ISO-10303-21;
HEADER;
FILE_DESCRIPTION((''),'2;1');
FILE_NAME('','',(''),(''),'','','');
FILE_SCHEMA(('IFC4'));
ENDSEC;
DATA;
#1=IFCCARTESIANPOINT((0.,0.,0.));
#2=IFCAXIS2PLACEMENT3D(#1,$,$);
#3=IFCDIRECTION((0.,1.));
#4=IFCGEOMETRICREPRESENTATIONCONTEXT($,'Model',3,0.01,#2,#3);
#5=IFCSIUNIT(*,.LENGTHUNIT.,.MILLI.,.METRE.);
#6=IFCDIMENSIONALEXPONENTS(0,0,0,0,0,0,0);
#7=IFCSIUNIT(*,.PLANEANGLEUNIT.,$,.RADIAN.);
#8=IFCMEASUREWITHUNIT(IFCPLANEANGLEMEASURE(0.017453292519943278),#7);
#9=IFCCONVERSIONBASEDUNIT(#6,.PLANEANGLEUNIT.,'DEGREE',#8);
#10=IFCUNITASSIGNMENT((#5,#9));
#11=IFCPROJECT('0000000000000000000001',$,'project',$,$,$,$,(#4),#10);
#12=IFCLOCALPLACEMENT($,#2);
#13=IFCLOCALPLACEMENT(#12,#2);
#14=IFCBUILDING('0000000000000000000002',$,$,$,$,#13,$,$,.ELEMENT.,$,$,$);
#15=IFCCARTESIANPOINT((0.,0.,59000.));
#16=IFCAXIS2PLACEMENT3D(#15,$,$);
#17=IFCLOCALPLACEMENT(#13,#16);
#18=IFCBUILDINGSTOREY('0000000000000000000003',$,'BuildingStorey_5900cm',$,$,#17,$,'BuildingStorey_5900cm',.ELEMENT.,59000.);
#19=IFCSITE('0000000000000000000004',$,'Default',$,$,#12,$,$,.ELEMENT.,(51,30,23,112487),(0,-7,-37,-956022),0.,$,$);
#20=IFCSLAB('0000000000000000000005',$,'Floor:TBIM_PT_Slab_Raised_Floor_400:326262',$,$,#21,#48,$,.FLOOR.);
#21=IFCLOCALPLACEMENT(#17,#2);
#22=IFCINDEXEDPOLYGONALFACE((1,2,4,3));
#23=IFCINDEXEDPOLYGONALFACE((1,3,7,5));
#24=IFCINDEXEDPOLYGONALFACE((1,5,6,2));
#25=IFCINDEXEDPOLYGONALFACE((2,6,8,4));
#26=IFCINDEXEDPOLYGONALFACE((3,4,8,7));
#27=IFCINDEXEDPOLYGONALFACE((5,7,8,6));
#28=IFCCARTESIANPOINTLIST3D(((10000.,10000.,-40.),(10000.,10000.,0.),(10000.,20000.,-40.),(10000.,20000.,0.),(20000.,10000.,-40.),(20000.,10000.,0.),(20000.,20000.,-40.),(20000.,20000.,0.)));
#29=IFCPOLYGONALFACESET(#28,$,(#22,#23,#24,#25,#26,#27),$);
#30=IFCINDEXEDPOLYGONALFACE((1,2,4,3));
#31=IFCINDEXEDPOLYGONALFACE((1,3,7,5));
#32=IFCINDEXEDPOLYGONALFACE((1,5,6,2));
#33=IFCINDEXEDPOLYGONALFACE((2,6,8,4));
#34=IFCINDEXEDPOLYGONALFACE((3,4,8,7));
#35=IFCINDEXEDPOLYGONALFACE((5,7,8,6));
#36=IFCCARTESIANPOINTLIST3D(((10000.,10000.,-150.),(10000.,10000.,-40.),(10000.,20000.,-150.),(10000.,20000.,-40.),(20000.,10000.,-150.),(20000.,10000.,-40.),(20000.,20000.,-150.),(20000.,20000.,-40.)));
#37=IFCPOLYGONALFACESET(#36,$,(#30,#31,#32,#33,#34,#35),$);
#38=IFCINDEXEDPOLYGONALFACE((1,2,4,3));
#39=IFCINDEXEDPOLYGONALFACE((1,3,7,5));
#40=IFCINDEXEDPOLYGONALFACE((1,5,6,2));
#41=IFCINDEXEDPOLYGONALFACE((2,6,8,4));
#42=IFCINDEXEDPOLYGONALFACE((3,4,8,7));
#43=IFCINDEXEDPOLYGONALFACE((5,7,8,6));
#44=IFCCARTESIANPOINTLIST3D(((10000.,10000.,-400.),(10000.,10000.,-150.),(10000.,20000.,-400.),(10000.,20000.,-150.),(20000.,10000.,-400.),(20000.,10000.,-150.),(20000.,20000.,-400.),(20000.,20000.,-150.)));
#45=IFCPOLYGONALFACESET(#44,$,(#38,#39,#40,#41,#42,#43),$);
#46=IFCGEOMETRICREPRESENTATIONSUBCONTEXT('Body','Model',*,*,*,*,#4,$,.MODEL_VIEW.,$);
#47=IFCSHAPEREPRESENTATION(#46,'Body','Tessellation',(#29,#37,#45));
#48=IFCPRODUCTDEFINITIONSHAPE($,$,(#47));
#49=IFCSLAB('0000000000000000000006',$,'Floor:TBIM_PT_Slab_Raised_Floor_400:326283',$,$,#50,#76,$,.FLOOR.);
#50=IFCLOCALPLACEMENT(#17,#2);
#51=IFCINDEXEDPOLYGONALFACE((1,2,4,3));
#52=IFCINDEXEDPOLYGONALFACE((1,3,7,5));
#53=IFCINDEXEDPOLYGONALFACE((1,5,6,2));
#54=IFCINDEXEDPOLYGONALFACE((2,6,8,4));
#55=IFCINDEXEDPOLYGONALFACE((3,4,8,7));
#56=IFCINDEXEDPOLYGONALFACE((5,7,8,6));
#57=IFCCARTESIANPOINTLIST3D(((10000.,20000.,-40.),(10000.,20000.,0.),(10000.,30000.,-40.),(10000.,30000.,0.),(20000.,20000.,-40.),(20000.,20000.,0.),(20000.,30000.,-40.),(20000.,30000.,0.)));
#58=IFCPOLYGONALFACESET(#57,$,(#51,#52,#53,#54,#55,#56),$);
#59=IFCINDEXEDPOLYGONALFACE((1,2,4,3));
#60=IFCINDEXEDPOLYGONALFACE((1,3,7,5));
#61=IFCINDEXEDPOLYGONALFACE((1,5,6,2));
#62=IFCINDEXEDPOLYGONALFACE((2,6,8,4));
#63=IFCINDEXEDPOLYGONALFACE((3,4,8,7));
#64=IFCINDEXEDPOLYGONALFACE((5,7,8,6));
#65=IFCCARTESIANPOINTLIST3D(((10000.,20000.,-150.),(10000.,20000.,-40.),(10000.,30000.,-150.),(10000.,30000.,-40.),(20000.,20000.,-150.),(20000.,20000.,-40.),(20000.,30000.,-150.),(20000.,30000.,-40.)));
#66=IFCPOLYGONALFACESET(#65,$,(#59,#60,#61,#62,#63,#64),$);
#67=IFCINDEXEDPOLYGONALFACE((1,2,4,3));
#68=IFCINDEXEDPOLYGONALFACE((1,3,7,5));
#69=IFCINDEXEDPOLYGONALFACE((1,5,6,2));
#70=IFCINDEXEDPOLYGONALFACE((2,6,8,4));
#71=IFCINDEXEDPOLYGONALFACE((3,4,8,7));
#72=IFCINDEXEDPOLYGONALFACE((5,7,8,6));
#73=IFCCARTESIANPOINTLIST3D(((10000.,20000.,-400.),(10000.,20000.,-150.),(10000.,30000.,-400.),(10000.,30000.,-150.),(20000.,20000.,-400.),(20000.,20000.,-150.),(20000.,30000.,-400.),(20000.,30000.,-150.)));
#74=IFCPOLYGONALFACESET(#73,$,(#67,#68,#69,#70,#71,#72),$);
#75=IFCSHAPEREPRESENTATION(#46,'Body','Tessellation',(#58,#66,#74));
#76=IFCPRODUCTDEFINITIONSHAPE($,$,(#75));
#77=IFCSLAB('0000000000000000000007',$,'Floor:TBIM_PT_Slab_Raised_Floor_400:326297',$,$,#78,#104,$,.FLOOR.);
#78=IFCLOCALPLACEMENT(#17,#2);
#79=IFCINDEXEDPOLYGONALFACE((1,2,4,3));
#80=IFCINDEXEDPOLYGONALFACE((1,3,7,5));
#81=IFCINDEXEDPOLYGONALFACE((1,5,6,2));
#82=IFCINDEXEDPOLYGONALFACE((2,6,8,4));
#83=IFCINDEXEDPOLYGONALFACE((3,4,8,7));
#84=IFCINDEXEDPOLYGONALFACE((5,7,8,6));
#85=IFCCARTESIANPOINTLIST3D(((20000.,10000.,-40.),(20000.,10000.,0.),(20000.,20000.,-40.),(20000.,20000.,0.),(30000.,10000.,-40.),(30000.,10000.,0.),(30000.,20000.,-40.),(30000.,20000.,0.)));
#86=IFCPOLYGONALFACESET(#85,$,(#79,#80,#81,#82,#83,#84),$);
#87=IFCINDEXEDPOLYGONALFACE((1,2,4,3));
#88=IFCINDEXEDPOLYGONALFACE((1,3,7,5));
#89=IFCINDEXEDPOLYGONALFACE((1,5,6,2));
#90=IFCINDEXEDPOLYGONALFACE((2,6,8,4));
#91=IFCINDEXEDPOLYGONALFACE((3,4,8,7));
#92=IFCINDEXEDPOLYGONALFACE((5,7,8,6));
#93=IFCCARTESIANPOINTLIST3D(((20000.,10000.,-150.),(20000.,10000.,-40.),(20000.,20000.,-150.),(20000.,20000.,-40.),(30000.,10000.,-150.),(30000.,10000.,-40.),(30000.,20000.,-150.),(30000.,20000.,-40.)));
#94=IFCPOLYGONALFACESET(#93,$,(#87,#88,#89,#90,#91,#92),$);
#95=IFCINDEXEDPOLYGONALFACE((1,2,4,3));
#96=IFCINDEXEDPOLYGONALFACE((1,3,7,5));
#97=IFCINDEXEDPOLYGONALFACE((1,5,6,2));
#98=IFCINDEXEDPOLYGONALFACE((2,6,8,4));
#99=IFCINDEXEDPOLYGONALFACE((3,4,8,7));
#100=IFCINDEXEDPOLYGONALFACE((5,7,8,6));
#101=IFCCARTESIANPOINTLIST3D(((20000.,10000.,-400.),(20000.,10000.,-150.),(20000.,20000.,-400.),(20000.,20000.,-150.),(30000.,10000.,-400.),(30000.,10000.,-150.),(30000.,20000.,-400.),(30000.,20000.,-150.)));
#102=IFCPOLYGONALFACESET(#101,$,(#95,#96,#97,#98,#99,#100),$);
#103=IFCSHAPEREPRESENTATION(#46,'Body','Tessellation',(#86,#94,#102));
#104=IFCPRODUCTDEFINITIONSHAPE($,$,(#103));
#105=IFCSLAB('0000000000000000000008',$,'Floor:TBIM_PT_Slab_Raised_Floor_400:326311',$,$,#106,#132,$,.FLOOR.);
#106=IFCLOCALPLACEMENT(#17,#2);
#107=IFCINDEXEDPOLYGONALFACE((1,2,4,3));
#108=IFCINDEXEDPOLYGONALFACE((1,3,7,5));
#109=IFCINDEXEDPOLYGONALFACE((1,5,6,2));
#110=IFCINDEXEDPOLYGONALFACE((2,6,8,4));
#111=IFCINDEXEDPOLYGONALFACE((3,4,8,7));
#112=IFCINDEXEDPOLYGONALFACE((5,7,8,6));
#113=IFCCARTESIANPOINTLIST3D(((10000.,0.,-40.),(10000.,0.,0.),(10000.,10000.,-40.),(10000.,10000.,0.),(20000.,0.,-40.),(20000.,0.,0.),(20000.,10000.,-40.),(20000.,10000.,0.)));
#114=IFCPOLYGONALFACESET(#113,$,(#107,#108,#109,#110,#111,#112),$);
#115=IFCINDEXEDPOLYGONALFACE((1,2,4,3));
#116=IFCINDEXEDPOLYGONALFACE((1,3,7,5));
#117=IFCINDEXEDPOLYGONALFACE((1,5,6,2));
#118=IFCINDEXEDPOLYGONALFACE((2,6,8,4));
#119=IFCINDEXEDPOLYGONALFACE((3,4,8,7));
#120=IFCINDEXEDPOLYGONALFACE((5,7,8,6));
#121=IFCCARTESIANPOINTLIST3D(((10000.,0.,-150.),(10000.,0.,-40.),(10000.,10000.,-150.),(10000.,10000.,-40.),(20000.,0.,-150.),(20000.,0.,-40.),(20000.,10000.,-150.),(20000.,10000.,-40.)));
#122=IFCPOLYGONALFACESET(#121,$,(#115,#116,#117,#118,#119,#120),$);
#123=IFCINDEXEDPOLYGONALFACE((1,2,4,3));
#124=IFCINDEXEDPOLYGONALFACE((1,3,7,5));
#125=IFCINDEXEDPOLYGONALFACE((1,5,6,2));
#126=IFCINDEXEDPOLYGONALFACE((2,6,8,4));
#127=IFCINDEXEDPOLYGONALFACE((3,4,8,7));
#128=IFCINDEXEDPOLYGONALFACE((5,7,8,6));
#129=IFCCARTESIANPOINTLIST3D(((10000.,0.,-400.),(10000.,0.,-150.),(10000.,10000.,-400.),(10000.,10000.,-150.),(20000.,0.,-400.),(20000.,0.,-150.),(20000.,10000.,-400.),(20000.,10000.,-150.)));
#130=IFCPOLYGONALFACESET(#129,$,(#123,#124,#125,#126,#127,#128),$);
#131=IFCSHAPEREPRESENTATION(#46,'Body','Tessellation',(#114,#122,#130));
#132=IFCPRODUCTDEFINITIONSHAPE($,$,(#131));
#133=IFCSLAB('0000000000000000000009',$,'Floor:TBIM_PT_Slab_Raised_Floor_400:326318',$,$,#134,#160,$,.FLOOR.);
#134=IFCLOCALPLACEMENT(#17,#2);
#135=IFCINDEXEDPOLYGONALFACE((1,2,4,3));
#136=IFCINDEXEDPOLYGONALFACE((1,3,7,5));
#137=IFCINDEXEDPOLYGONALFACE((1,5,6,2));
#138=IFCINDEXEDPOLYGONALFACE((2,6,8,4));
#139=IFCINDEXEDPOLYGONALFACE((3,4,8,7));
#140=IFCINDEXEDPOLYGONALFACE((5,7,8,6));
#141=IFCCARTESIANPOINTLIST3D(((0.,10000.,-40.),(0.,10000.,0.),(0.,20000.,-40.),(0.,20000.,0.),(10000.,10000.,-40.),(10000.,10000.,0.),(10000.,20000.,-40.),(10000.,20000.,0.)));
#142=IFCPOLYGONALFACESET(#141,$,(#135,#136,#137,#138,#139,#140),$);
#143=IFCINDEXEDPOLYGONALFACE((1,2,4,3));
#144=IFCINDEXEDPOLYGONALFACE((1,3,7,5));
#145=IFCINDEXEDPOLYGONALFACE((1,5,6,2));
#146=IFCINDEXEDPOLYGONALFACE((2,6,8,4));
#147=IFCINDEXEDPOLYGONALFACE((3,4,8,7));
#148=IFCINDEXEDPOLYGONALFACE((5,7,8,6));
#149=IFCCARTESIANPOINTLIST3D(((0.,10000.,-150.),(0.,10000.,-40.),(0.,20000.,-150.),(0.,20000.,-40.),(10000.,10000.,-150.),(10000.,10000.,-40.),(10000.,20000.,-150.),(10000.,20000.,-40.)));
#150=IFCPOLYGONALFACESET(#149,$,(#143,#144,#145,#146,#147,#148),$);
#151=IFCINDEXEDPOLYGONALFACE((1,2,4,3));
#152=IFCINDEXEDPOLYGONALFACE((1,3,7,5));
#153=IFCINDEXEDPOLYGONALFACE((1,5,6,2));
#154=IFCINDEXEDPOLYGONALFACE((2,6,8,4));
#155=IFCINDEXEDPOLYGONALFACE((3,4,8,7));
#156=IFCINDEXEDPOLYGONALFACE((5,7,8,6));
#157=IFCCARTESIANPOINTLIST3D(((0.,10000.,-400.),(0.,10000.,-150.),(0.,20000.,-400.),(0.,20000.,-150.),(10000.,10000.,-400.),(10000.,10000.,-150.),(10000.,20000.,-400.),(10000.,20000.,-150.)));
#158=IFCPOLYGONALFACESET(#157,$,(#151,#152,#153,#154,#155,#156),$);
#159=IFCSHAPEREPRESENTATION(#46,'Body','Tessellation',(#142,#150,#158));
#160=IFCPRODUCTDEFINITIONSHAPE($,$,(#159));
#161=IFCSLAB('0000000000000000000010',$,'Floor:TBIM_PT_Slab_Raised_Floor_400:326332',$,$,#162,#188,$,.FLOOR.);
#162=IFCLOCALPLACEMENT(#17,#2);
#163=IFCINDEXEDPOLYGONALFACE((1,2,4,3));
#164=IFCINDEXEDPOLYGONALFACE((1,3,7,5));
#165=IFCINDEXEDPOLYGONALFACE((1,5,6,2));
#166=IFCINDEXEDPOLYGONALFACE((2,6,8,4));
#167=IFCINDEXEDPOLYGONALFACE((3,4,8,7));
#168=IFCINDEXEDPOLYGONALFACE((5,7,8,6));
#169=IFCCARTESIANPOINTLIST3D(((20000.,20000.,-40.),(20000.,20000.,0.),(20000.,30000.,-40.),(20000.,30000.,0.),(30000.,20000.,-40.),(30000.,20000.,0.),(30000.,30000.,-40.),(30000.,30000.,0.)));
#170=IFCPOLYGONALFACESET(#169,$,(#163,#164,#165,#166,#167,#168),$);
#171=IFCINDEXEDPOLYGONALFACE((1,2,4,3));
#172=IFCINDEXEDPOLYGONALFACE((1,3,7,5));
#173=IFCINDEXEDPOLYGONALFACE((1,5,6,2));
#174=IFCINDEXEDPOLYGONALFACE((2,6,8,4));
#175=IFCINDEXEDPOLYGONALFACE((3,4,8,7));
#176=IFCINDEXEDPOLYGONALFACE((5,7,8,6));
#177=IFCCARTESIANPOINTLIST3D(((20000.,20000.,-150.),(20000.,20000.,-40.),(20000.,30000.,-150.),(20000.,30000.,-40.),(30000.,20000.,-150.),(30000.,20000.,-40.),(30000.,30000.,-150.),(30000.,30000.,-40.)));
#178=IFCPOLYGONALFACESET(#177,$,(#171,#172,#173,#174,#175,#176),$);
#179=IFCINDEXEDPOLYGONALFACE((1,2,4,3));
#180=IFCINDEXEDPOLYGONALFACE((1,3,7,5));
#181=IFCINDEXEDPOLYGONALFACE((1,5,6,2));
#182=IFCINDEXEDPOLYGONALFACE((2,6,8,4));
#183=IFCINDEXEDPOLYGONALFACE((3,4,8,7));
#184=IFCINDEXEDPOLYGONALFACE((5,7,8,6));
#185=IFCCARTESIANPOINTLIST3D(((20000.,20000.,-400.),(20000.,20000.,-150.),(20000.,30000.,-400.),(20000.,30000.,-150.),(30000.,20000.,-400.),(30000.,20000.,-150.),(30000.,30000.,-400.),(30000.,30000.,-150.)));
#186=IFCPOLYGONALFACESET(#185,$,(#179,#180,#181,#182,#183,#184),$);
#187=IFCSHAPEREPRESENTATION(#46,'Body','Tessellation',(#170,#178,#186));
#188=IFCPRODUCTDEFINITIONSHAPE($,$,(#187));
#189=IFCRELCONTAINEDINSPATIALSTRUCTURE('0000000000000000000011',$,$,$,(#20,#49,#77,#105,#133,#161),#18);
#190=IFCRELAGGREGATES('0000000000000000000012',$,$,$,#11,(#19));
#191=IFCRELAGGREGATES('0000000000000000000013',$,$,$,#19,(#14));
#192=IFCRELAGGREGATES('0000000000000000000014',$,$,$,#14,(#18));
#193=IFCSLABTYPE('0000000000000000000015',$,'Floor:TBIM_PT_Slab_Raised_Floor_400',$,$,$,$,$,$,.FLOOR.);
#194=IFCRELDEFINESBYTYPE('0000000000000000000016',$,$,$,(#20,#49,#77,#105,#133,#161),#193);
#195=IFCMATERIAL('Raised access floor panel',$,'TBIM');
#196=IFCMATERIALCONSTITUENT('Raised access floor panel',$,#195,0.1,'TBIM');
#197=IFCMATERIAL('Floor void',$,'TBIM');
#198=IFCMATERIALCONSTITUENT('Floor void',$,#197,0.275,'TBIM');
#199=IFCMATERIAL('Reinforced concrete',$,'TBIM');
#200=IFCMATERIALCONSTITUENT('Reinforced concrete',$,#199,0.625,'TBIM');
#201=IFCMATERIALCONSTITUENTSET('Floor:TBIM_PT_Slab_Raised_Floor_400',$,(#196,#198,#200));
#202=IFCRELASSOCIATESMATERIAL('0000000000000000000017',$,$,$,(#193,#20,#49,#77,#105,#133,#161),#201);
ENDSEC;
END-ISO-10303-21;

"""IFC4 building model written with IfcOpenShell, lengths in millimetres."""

from ifc_helpers import new_model, entity, si_unit, converted_unit, direction, frame, origin, place, context, subcontext, project, spatial, indexed_curve, outline, extrude, material, constituent, constituent_set, type_object, element, save


model = new_model("IFC4")

# Units and contexts
model_context = context("Model", 3, precision=0.01, world=origin(), true_north=direction((0.0, 1.0)))
body_context = subcontext(model_context, "Body", "Model", "MODEL_VIEW")
ifc_project = project(units=[si_unit("LENGTHUNIT", "METRE", prefix="MILLI"), converted_unit("PLANEANGLEUNIT", "DEGREE", entity("IfcPlaneAngleMeasure", 0.017453292519943278), si_unit("PLANEANGLEUNIT", "RADIAN"), dimensions=[0, 0, 0, 0, 0, 0, 0])], contexts=[model_context])

# Site, building, storey
site_placement = place(None, origin())
site = spatial("IfcSite", under=ifc_project, at=site_placement, Name="Default", CompositionType="ELEMENT", RefLatitude=(51, 30, 23, 112487), RefLongitude=(0, -7, -37, -956022), RefElevation=0.0)
building_placement = place(site_placement, origin())
building = spatial("IfcBuilding", under=site, at=building_placement, CompositionType="ELEMENT")
storey_placement = place(building_placement, frame((0.0, 0.0, 59000.0)))
storey = spatial("IfcBuildingStorey", under=building, at=storey_placement, Name="BuildingStorey_5900cm", LongName="BuildingStorey_5900cm", CompositionType="ELEMENT", Elevation=59000.0)

# Slabs
ifc_material_1 = material(Name="Raised access floor panel", Category="TBIM")
ifc_constituent_1 = constituent(ifc_material_1, Name="Raised access floor panel", Category="TBIM", fraction=0.1)
ifc_material_2 = material(Name="Floor void", Category="TBIM")
ifc_constituent_2 = constituent(ifc_material_2, Name="Floor void", Category="TBIM", fraction=0.275)
ifc_material_3 = material(Name="Reinforced concrete", Category="TBIM")
ifc_constituent_3 = constituent(ifc_material_3, Name="Reinforced concrete", Category="TBIM", fraction=0.625)
ifc_constituent_set_1 = constituent_set(constituents=[ifc_constituent_1, ifc_constituent_2, ifc_constituent_3], Name="Floor:TBIM_PT_Slab_Raised_Floor_400")
slab_type = type_object("IfcSlabType", Name="Floor:TBIM_PT_Slab_Raised_Floor_400", PredefinedType="FLOOR", material=ifc_constituent_set_1)
slab_1_placement = place(storey_placement, origin())
element("IfcSlab", 1, at=slab_1_placement, inside=storey, type_object=slab_type, material=ifc_constituent_set_1, Name="Floor:TBIM_PT_Slab_Raised_Floor_400:326262", PredefinedType="FLOOR", context=body_context, shape_type="SweptSolid", body=[
    extrude(outline(indexed_curve([(-5000.0, -5000.0), (5000.0, -5000.0), (5000.0, 5000.0), (-5000.0, 5000.0), (-5000.0, -5000.0)], self_intersect=False)), frame((15000.0, 15000.0, -40.0), z_axis=(0.0, 0.0, 1.0), x_axis=(-1.0, 0.0, 0.0)), (0.0, 0.0, 1.0), 40.0),
    extrude(outline(indexed_curve([(-5000.0, -5000.0), (5000.0, -5000.0), (5000.0, 5000.0), (-5000.0, 5000.0), (-5000.0, -5000.0)], self_intersect=False)), frame((15000.0, 15000.0, -150.0), z_axis=(0.0, 0.0, 1.0), x_axis=(-1.0, 0.0, 0.0)), (0.0, 0.0, 1.0), 110.0),
    extrude(outline(indexed_curve([(-5000.0, -5000.0), (5000.0, -5000.0), (5000.0, 5000.0), (-5000.0, 5000.0), (-5000.0, -5000.0)], self_intersect=False)), frame((15000.0, 15000.0, -400.0), z_axis=(0.0, 0.0, 1.0), x_axis=(-1.0, 0.0, 0.0)), (0.0, 0.0, 1.0), 250.0),
])
slab_2_placement = place(storey_placement, origin())
element("IfcSlab", 2, at=slab_2_placement, inside=storey, type_object=slab_type, material=ifc_constituent_set_1, Name="Floor:TBIM_PT_Slab_Raised_Floor_400:326283", PredefinedType="FLOOR", context=body_context, shape_type="SweptSolid", body=[
    extrude(outline(indexed_curve([(-5000.0, -5000.0), (5000.0, -5000.0), (5000.0, 5000.0), (-5000.0, 5000.0), (-5000.0, -5000.0)], self_intersect=False)), frame((15000.0, 25000.0, -40.0), z_axis=(0.0, 0.0, 1.0), x_axis=(-1.0, 0.0, 0.0)), (0.0, 0.0, 1.0), 40.0),
    extrude(outline(indexed_curve([(-5000.0, -5000.0), (5000.0, -5000.0), (5000.0, 5000.0), (-5000.0, 5000.0), (-5000.0, -5000.0)], self_intersect=False)), frame((15000.0, 25000.0, -150.0), z_axis=(0.0, 0.0, 1.0), x_axis=(-1.0, 0.0, 0.0)), (0.0, 0.0, 1.0), 110.0),
    extrude(outline(indexed_curve([(-5000.0, -5000.0), (5000.0, -5000.0), (5000.0, 5000.0), (-5000.0, 5000.0), (-5000.0, -5000.0)], self_intersect=False)), frame((15000.0, 25000.0, -400.0), z_axis=(0.0, 0.0, 1.0), x_axis=(-1.0, 0.0, 0.0)), (0.0, 0.0, 1.0), 250.0),
])
slab_3_placement = place(storey_placement, origin())
element("IfcSlab", 3, at=slab_3_placement, inside=storey, type_object=slab_type, material=ifc_constituent_set_1, Name="Floor:TBIM_PT_Slab_Raised_Floor_400:326297", PredefinedType="FLOOR", context=body_context, shape_type="SweptSolid", body=[
    extrude(outline(indexed_curve([(-5000.0, -5000.0), (5000.0, -5000.0), (5000.0, 5000.0), (-5000.0, 5000.0), (-5000.0, -5000.0)], self_intersect=False)), frame((25000.0, 15000.0, -40.0), z_axis=(0.0, 0.0, 1.0), x_axis=(-1.0, 0.0, 0.0)), (0.0, 0.0, 1.0), 40.0),
    extrude(outline(indexed_curve([(-5000.0, -5000.0), (5000.0, -5000.0), (5000.0, 5000.0), (-5000.0, 5000.0), (-5000.0, -5000.0)], self_intersect=False)), frame((25000.0, 15000.0, -150.0), z_axis=(0.0, 0.0, 1.0), x_axis=(-1.0, 0.0, 0.0)), (0.0, 0.0, 1.0), 110.0),
    extrude(outline(indexed_curve([(-5000.0, -5000.0), (5000.0, -5000.0), (5000.0, 5000.0), (-5000.0, 5000.0), (-5000.0, -5000.0)], self_intersect=False)), frame((25000.0, 15000.0, -400.0), z_axis=(0.0, 0.0, 1.0), x_axis=(-1.0, 0.0, 0.0)), (0.0, 0.0, 1.0), 250.0),
])
slab_4_placement = place(storey_placement, origin())
element("IfcSlab", 4, at=slab_4_placement, inside=storey, type_object=slab_type, material=ifc_constituent_set_1, Name="Floor:TBIM_PT_Slab_Raised_Floor_400:326311", PredefinedType="FLOOR", context=body_context, shape_type="SweptSolid", body=[
    extrude(outline(indexed_curve([(-5000.0, -5000.0), (5000.0, -5000.0), (5000.0, 5000.0), (-5000.0, 5000.0), (-5000.0, -5000.0)], self_intersect=False)), frame((15000.0, 5000.0, -40.0), z_axis=(0.0, 0.0, 1.0), x_axis=(0.0, 1.0, 0.0)), (0.0, 0.0, 1.0), 40.0),
    extrude(outline(indexed_curve([(-5000.0, -5000.0), (5000.0, -5000.0), (5000.0, 5000.0), (-5000.0, 5000.0), (-5000.0, -5000.0)], self_intersect=False)), frame((15000.0, 5000.0, -150.0), z_axis=(0.0, 0.0, 1.0), x_axis=(0.0, 1.0, 0.0)), (0.0, 0.0, 1.0), 110.0),
    extrude(outline(indexed_curve([(-5000.0, -5000.0), (5000.0, -5000.0), (5000.0, 5000.0), (-5000.0, 5000.0), (-5000.0, -5000.0)], self_intersect=False)), frame((15000.0, 5000.0, -400.0), z_axis=(0.0, 0.0, 1.0), x_axis=(0.0, 1.0, 0.0)), (0.0, 0.0, 1.0), 250.0),
])
slab_5_placement = place(storey_placement, origin())
element("IfcSlab", 5, at=slab_5_placement, inside=storey, type_object=slab_type, material=ifc_constituent_set_1, Name="Floor:TBIM_PT_Slab_Raised_Floor_400:326318", PredefinedType="FLOOR", context=body_context, shape_type="SweptSolid", body=[
    extrude(outline(indexed_curve([(-5000.0, -5000.0), (5000.0, -5000.0), (5000.0, 5000.0), (-5000.0, 5000.0), (-5000.0, -5000.0)], self_intersect=False)), frame((5000.0, 15000.0, -40.0), z_axis=(0.0, 0.0, 1.0), x_axis=(0.0, 1.0, 0.0)), (0.0, 0.0, 1.0), 40.0),
    extrude(outline(indexed_curve([(-5000.0, -5000.0), (5000.0, -5000.0), (5000.0, 5000.0), (-5000.0, 5000.0), (-5000.0, -5000.0)], self_intersect=False)), frame((5000.0, 15000.0, -150.0), z_axis=(0.0, 0.0, 1.0), x_axis=(0.0, 1.0, 0.0)), (0.0, 0.0, 1.0), 110.0),
    extrude(outline(indexed_curve([(-5000.0, -5000.0), (5000.0, -5000.0), (5000.0, 5000.0), (-5000.0, 5000.0), (-5000.0, -5000.0)], self_intersect=False)), frame((5000.0, 15000.0, -400.0), z_axis=(0.0, 0.0, 1.0), x_axis=(0.0, 1.0, 0.0)), (0.0, 0.0, 1.0), 250.0),
])
slab_6_placement = place(storey_placement, origin())
element("IfcSlab", 6, at=slab_6_placement, inside=storey, type_object=slab_type, material=ifc_constituent_set_1, Name="Floor:TBIM_PT_Slab_Raised_Floor_400:326332", PredefinedType="FLOOR", context=body_context, shape_type="SweptSolid", body=[
    extrude(outline(indexed_curve([(-5000.0, -5000.0), (5000.0, -5000.0), (5000.0, 5000.0), (-5000.0, 5000.0), (-5000.0, -5000.0)], self_intersect=False)), frame((25000.0, 25000.0, -40.0), z_axis=(0.0, 0.0, 1.0), x_axis=(-1.0, 0.0, 0.0)), (0.0, 0.0, 1.0), 40.0),
    extrude(outline(indexed_curve([(-5000.0, -5000.0), (5000.0, -5000.0), (5000.0, 5000.0), (-5000.0, 5000.0), (-5000.0, -5000.0)], self_intersect=False)), frame((25000.0, 25000.0, -150.0), z_axis=(0.0, 0.0, 1.0), x_axis=(-1.0, 0.0, 0.0)), (0.0, 0.0, 1.0), 110.0),
    extrude(outline(indexed_curve([(-5000.0, -5000.0), (5000.0, -5000.0), (5000.0, 5000.0), (-5000.0, 5000.0), (-5000.0, -5000.0)], self_intersect=False)), frame((25000.0, 25000.0, -400.0), z_axis=(0.0, 0.0, 1.0), x_axis=(-1.0, 0.0, 0.0)), (0.0, 0.0, 1.0), 250.0),
])

save(model, "model.ifc")
